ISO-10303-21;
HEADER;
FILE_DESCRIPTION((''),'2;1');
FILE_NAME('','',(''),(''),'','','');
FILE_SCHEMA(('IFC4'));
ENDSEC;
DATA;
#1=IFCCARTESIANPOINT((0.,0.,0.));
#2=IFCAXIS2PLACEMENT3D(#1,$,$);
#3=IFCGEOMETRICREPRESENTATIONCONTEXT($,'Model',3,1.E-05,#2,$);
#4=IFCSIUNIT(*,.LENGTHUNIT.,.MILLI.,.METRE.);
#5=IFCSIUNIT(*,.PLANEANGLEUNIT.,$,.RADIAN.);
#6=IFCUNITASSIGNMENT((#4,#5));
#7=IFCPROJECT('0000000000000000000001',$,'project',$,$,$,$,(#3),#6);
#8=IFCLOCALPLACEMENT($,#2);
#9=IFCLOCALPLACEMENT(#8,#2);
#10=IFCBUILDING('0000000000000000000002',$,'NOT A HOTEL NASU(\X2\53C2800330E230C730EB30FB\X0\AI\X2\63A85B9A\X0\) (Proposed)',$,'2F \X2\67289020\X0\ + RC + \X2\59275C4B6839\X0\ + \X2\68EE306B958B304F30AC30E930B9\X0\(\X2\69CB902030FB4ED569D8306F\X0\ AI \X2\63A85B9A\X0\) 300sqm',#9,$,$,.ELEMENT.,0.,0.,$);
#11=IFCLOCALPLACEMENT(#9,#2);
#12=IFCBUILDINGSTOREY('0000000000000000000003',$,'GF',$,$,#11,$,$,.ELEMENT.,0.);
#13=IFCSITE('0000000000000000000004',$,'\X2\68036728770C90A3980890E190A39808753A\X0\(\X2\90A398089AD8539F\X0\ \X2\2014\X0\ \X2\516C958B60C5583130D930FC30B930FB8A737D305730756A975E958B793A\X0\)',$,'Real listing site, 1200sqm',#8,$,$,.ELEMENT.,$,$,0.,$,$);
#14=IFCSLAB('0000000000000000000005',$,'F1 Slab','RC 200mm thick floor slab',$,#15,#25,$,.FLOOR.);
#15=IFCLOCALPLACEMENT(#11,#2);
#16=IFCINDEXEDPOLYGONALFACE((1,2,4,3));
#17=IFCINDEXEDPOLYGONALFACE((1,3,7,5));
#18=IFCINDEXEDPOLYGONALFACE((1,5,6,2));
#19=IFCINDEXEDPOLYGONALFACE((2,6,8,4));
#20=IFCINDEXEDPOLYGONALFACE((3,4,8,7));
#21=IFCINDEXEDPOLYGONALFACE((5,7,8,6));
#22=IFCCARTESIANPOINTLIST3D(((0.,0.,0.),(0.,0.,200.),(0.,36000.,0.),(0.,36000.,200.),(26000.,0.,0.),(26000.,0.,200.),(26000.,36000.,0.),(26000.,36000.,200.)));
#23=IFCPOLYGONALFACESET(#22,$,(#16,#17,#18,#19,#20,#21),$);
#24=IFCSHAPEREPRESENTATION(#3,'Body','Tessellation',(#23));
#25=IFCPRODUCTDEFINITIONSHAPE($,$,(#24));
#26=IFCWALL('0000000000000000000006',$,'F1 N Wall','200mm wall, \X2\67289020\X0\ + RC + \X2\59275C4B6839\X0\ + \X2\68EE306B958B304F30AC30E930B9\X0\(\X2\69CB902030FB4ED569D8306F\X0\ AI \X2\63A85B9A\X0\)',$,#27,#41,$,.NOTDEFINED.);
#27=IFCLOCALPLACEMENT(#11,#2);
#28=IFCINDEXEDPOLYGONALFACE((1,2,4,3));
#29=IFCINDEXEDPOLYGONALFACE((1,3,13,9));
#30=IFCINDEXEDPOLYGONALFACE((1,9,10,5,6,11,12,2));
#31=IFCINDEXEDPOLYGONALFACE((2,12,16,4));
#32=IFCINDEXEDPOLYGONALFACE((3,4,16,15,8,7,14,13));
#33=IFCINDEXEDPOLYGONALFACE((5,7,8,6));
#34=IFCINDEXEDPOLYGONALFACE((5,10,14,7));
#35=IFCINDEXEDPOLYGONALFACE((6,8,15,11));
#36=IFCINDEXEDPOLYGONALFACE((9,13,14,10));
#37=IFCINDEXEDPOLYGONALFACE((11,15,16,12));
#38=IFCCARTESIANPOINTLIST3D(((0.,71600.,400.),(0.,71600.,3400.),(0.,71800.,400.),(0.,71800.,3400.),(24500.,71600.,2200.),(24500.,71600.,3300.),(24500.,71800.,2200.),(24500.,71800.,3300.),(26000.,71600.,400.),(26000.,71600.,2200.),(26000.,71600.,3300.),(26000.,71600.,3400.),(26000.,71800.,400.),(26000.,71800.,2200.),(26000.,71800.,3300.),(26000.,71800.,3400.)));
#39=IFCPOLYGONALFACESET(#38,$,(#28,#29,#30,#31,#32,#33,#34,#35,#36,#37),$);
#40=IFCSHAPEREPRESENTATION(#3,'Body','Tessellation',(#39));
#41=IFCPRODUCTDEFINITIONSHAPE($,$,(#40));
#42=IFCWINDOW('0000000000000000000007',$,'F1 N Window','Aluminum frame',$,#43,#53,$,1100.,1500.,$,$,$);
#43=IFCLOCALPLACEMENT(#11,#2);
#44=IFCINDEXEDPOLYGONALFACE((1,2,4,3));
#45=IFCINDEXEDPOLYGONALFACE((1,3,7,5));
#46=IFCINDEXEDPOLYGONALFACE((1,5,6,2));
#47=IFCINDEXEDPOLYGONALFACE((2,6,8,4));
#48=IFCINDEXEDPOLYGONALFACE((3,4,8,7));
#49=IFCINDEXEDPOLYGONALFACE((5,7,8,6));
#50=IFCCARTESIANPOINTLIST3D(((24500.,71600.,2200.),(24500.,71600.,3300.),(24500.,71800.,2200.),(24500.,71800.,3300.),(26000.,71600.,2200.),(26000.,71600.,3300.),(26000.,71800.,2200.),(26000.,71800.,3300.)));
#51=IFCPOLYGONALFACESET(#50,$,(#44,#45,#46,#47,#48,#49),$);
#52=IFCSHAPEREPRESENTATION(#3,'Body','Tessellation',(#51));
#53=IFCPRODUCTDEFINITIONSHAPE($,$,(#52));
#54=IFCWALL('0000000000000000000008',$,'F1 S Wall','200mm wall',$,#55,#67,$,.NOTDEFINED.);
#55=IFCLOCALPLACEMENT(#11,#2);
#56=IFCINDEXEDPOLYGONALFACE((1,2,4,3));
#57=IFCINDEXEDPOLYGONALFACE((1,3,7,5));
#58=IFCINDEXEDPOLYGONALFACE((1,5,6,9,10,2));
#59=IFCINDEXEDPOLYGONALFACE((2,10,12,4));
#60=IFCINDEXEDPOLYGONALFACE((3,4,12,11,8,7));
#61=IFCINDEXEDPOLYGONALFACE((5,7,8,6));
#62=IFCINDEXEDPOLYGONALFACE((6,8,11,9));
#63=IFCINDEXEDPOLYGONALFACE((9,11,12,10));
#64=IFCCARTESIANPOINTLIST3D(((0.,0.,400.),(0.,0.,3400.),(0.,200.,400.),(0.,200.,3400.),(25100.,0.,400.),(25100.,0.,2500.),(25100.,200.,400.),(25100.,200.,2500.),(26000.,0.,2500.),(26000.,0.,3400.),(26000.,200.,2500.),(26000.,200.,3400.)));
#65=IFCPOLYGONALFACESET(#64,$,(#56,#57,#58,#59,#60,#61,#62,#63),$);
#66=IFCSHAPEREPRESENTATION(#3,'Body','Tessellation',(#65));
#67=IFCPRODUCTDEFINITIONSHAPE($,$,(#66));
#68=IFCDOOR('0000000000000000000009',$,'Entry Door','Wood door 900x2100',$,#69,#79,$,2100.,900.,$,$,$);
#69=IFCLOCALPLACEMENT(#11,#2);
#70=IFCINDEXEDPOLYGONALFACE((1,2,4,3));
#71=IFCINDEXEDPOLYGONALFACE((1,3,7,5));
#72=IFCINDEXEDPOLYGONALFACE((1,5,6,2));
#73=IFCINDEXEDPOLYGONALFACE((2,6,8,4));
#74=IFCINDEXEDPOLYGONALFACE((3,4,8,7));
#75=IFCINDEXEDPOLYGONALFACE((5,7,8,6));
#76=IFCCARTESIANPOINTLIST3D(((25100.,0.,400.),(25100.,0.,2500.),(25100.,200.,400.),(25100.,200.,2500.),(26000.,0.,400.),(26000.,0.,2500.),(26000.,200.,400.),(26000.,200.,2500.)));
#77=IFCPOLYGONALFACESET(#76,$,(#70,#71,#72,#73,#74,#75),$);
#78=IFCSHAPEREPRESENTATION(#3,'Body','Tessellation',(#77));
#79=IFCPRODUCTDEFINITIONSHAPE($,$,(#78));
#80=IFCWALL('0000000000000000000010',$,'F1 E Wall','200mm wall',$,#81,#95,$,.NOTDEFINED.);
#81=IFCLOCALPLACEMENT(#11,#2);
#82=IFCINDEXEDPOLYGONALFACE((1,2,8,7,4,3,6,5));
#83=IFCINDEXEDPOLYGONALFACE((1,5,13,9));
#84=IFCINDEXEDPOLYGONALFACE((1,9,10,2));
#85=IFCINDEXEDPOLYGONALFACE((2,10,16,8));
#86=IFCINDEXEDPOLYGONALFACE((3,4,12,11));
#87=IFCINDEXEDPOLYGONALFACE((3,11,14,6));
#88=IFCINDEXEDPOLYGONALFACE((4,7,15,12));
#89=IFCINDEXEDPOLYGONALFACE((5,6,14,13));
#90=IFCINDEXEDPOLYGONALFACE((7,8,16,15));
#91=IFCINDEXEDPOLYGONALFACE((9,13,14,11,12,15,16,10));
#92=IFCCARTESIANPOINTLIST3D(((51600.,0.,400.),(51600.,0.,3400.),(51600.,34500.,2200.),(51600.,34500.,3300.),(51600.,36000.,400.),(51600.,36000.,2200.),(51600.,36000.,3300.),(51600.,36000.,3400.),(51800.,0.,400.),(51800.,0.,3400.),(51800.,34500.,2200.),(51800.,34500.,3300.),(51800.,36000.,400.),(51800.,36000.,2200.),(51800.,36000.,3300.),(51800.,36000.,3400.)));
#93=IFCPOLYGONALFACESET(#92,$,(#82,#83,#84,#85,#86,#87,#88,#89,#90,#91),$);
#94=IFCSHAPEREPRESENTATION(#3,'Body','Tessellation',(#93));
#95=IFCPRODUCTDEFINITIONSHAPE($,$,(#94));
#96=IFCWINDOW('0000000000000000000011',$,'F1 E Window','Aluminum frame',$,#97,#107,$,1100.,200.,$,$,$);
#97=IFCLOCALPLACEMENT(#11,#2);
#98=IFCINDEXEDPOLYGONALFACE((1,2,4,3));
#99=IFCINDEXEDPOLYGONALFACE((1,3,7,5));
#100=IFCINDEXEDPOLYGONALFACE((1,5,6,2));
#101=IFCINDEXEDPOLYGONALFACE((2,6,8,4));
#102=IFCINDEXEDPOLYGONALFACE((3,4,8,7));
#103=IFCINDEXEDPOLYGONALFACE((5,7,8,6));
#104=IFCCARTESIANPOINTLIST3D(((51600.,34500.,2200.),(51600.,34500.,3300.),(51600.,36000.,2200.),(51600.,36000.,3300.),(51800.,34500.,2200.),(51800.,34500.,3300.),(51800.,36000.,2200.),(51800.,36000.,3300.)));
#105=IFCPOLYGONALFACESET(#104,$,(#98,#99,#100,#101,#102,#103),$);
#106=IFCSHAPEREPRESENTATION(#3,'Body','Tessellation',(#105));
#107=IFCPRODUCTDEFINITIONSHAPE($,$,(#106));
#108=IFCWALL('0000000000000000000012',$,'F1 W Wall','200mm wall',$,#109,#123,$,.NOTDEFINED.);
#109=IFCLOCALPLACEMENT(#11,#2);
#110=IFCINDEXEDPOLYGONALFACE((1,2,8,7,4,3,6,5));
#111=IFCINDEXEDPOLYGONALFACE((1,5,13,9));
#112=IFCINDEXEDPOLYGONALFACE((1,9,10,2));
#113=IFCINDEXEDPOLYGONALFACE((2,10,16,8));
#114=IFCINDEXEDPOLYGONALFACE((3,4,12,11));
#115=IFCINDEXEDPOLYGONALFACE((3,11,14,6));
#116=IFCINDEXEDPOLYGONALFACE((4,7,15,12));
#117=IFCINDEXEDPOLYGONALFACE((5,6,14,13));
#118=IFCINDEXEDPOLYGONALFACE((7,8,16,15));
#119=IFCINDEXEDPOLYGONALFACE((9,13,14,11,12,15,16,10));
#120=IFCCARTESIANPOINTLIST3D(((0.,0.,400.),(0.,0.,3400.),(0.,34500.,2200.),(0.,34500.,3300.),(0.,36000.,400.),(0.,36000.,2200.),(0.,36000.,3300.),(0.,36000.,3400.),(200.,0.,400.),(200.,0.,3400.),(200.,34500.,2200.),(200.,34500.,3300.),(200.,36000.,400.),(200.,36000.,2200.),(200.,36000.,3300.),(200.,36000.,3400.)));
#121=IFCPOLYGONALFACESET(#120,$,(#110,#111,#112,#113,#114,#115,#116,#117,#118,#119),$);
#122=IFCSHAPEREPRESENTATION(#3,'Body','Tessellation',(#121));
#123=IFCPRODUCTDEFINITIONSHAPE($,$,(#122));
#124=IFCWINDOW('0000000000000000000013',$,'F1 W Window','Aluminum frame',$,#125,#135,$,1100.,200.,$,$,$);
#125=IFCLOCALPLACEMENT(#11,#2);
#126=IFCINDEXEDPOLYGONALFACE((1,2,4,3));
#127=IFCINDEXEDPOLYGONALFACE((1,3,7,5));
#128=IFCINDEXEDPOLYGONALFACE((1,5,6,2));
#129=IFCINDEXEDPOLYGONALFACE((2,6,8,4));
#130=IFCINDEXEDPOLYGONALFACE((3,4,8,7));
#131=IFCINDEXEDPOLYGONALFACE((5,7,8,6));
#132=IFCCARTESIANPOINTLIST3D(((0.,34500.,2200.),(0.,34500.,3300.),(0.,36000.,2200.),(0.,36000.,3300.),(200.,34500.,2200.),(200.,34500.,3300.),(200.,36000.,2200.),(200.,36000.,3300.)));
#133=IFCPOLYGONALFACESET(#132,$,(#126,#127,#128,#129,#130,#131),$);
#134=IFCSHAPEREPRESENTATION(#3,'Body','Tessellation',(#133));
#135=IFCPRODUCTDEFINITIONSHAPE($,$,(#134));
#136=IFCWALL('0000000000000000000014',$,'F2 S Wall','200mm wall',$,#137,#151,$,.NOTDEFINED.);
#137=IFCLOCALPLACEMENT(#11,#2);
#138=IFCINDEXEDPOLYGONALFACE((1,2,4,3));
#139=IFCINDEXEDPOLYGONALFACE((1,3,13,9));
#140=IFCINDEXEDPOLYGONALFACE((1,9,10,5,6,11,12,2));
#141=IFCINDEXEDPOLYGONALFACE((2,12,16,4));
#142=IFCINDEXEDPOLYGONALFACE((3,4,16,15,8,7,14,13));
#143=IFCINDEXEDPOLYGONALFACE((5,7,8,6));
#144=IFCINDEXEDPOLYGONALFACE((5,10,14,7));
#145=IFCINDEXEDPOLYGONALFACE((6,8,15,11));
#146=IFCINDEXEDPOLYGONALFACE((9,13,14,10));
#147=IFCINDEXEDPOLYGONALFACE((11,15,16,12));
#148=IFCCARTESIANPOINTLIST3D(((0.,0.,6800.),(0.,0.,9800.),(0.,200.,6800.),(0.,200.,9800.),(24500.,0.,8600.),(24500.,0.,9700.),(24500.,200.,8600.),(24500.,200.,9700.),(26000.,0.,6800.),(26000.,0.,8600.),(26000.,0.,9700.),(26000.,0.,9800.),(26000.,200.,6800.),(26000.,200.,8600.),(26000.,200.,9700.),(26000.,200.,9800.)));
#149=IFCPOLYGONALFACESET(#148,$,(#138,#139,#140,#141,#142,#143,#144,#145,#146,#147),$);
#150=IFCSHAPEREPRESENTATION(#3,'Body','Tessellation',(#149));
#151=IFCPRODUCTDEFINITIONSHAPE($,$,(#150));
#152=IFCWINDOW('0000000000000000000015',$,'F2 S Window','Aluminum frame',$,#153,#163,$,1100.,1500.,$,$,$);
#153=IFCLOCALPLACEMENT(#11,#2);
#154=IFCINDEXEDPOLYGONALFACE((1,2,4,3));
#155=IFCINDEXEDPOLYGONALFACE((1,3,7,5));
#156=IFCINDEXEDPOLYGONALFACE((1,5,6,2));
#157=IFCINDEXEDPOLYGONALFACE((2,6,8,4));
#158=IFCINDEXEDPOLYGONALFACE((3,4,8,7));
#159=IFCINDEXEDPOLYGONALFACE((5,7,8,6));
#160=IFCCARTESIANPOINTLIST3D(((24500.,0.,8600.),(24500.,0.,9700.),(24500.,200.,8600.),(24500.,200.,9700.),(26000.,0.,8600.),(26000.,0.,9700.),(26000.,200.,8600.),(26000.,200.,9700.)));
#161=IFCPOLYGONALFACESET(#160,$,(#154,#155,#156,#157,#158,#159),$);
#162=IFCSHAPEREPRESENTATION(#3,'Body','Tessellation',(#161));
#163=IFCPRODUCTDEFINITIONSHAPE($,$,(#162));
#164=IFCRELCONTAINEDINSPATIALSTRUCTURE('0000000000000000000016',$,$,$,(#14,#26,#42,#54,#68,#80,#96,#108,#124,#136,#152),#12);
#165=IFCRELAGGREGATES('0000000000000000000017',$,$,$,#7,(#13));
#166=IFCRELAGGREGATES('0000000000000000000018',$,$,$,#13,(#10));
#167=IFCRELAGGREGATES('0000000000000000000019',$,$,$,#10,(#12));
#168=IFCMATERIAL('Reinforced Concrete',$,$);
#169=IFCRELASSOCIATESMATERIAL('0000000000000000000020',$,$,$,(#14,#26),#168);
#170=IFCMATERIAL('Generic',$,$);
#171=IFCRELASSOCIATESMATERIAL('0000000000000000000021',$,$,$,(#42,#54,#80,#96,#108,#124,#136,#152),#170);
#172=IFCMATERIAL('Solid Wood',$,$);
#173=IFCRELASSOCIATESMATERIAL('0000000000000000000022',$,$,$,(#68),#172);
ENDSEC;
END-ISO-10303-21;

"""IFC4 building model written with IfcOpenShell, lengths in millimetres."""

from ifc_helpers import new_model, si_unit, frame, frame_2d, origin, place, context, project, spatial, rectangle, extrude, material, element, fill, save


model = new_model("IFC4")

# Units and contexts
model_context = context("Model", 3, precision=1e-05, world=origin())
ifc_project = project(units=[si_unit("LENGTHUNIT", "METRE", prefix="MILLI"), si_unit("PLANEANGLEUNIT", "RADIAN")], contexts=[model_context])

# Site, building, storey
site_placement = place(None, origin())
site = spatial("IfcSite", under=ifc_project, at=site_placement, Name="栃木県那須郡那須町(那須高原 — 公開情報ベース・詳細地番非開示)", ObjectType="Real listing site, 1200sqm", CompositionType="ELEMENT", RefElevation=0.0)
building_placement = place(site_placement, origin())
building = spatial("IfcBuilding", under=site, at=building_placement, Name="NOT A HOTEL NASU(参考モデル・AI推定) (Proposed)", ObjectType="2F 木造 + RC + 大屋根 + 森に開くガラス(構造・仕様は AI 推定) 300sqm", CompositionType="ELEMENT", ElevationOfRefHeight=0.0, ElevationOfTerrain=0.0)
storey_placement = place(building_placement, origin())
storey = spatial("IfcBuildingStorey", under=building, at=storey_placement, Name="GF", CompositionType="ELEMENT", Elevation=0.0)

# Slab
ifc_material_1 = material(Name="Reinforced Concrete")
slab_1_placement = place(storey_placement, origin())
element("IfcSlab", 1, at=slab_1_placement, inside=storey, material=ifc_material_1, Name="F1 Slab", Description="RC 200mm thick floor slab", PredefinedType="FLOOR", context=model_context, shape_type="SweptSolid", body=[
    extrude(rectangle(XDim=26000.0, YDim=36000.0, at=frame_2d((13000.0, 18000.0))), origin(), (0.0, 0.0, 1.0), 200.0),
])

# Wall, opening, window
wall_1_placement = place(storey_placement, frame((0.0, 35800.0, 200.0)))
wall_1 = element("IfcWall", 2, at=wall_1_placement, inside=storey, material=ifc_material_1, Name="F1 N Wall", Description="200mm wall, 木造 + RC + 大屋根 + 森に開くガラス(構造・仕様は AI 推定)", PredefinedType="NOTDEFINED", context=model_context, shape_type="SweptSolid", body=[
    extrude(rectangle(XDim=26000.0, YDim=200.0, at=frame_2d((13000.0, 100.0))), frame((0.0, 35800.0, 200.0)), (0.0, 0.0, 1.0), 3000.0),
])
opening_1_placement = place(storey_placement, frame((12250.0, 35800.0, 1100.0)))
opening_1 = element("IfcOpeningElement", 3, at=opening_1_placement, cuts=wall_1, PredefinedType="NOTDEFINED", context=model_context, shape_type="SweptSolid", body=[
    extrude(rectangle(XDim=1500.0, YDim=200.0, at=frame_2d((750.0, 100.0))), frame((12250.0, 35800.0, 1100.0)), (0.0, 0.0, 1.0), 1100.0),
])
ifc_material_2 = material(Name="Generic")
window_1_placement = place(storey_placement, frame((12250.0, 35800.0, 1100.0)))
window_1 = element("IfcWindow", 4, at=window_1_placement, inside=storey, material=ifc_material_2, Name="F1 N Window", Description="Aluminum frame", OverallHeight=1100.0, OverallWidth=1500.0, context=model_context, shape_type="SweptSolid", body=[
    extrude(rectangle(XDim=1500.0, YDim=200.0, at=frame_2d((750.0, 100.0))), frame((12250.0, 35800.0, 1100.0)), (0.0, 0.0, 1.0), 1100.0),
])
fill(opening_1, window_1)

# Wall, opening, door
wall_2_placement = place(storey_placement, frame((0.0, 0.0, 200.0)))
wall_2 = element("IfcWall", 5, at=wall_2_placement, inside=storey, material=ifc_material_2, Name="F1 S Wall", Description="200mm wall", PredefinedType="NOTDEFINED", context=model_context, shape_type="SweptSolid", body=[
    extrude(rectangle(XDim=26000.0, YDim=200.0, at=frame_2d((13000.0, 100.0))), frame((0.0, 0.0, 200.0)), (0.0, 0.0, 1.0), 3000.0),
])
opening_2_placement = place(storey_placement, frame((12550.0, 0.0, 200.0)))
opening_2 = element("IfcOpeningElement", 6, at=opening_2_placement, cuts=wall_2, PredefinedType="NOTDEFINED", context=model_context, shape_type="SweptSolid", body=[
    extrude(rectangle(XDim=900.0, YDim=200.0, at=frame_2d((450.0, 100.0))), frame((12550.0, 0.0, 200.0)), (0.0, 0.0, 1.0), 2100.0),
])
ifc_material_3 = material(Name="Solid Wood")
door_placement = place(storey_placement, frame((12550.0, 0.0, 200.0)))
door = element("IfcDoor", 7, at=door_placement, inside=storey, material=ifc_material_3, Name="Entry Door", Description="Wood door 900x2100", OverallHeight=2100.0, OverallWidth=900.0, context=model_context, shape_type="SweptSolid", body=[
    extrude(rectangle(XDim=900.0, YDim=200.0, at=frame_2d((450.0, 100.0))), frame((12550.0, 0.0, 200.0)), (0.0, 0.0, 1.0), 2100.0),
])
fill(opening_2, door)

# Walls, openings, windows
wall_3_placement = place(storey_placement, frame((25800.0, 0.0, 200.0)))
wall_3 = element("IfcWall", 8, at=wall_3_placement, inside=storey, material=ifc_material_2, Name="F1 E Wall", Description="200mm wall", PredefinedType="NOTDEFINED", context=model_context, shape_type="SweptSolid", body=[
    extrude(rectangle(XDim=200.0, YDim=36000.0, at=frame_2d((100.0, 18000.0))), frame((25800.0, 0.0, 200.0)), (0.0, 0.0, 1.0), 3000.0),
])
opening_3_placement = place(storey_placement, frame((25800.0, 17250.0, 1100.0)))
opening_3 = element("IfcOpeningElement", 9, at=opening_3_placement, cuts=wall_3, PredefinedType="NOTDEFINED", context=model_context, shape_type="SweptSolid", body=[
    extrude(rectangle(XDim=200.0, YDim=1500.0, at=frame_2d((100.0, 750.0))), frame((25800.0, 17250.0, 1100.0)), (0.0, 0.0, 1.0), 1100.0),
])
window_2_placement = place(storey_placement, frame((25800.0, 17250.0, 1100.0)))
window_2 = element("IfcWindow", 10, at=window_2_placement, inside=storey, material=ifc_material_2, Name="F1 E Window", Description="Aluminum frame", OverallHeight=1100.0, OverallWidth=200.0, context=model_context, shape_type="SweptSolid", body=[
    extrude(rectangle(XDim=200.0, YDim=1500.0, at=frame_2d((100.0, 750.0))), frame((25800.0, 17250.0, 1100.0)), (0.0, 0.0, 1.0), 1100.0),
])
fill(opening_3, window_2)
wall_4_placement = place(storey_placement, frame((0.0, 0.0, 200.0)))
wall_4 = element("IfcWall", 11, at=wall_4_placement, inside=storey, material=ifc_material_2, Name="F1 W Wall", Description="200mm wall", PredefinedType="NOTDEFINED", context=model_context, shape_type="SweptSolid", body=[
    extrude(rectangle(XDim=200.0, YDim=36000.0, at=frame_2d((100.0, 18000.0))), frame((0.0, 0.0, 200.0)), (0.0, 0.0, 1.0), 3000.0),
])
opening_4_placement = place(storey_placement, frame((0.0, 17250.0, 1100.0)))
opening_4 = element("IfcOpeningElement", 12, at=opening_4_placement, cuts=wall_4, PredefinedType="NOTDEFINED", context=model_context, shape_type="SweptSolid", body=[
    extrude(rectangle(XDim=200.0, YDim=1500.0, at=frame_2d((100.0, 750.0))), frame((0.0, 17250.0, 1100.0)), (0.0, 0.0, 1.0), 1100.0),
])
window_3_placement = place(storey_placement, frame((0.0, 17250.0, 1100.0)))
window_3 = element("IfcWindow", 13, at=window_3_placement, inside=storey, material=ifc_material_2, Name="F1 W Window", Description="Aluminum frame", OverallHeight=1100.0, OverallWidth=200.0, context=model_context, shape_type="SweptSolid", body=[
    extrude(rectangle(XDim=200.0, YDim=1500.0, at=frame_2d((100.0, 750.0))), frame((0.0, 17250.0, 1100.0)), (0.0, 0.0, 1.0), 1100.0),
])
fill(opening_4, window_3)
wall_5_placement = place(storey_placement, frame((0.0, 0.0, 3400.0)))
wall_5 = element("IfcWall", 14, at=wall_5_placement, inside=storey, material=ifc_material_2, Name="F2 S Wall", Description="200mm wall", PredefinedType="NOTDEFINED", context=model_context, shape_type="SweptSolid", body=[
    extrude(rectangle(XDim=26000.0, YDim=200.0, at=frame_2d((13000.0, 100.0))), frame((0.0, 0.0, 3400.0)), (0.0, 0.0, 1.0), 3000.0),
])
opening_5_placement = place(storey_placement, frame((12250.0, 0.0, 4300.0)))
opening_5 = element("IfcOpeningElement", 15, at=opening_5_placement, cuts=wall_5, PredefinedType="NOTDEFINED", context=model_context, shape_type="SweptSolid", body=[
    extrude(rectangle(XDim=1500.0, YDim=200.0, at=frame_2d((750.0, 100.0))), frame((12250.0, 0.0, 4300.0)), (0.0, 0.0, 1.0), 1100.0),
])
window_4_placement = place(storey_placement, frame((12250.0, 0.0, 4300.0)))
window_4 = element("IfcWindow", 16, at=window_4_placement, inside=storey, material=ifc_material_2, Name="F2 S Window", Description="Aluminum frame", OverallHeight=1100.0, OverallWidth=1500.0, context=model_context, shape_type="SweptSolid", body=[
    extrude(rectangle(XDim=1500.0, YDim=200.0, at=frame_2d((750.0, 100.0))), frame((12250.0, 0.0, 4300.0)), (0.0, 0.0, 1.0), 1100.0),
])
fill(opening_5, window_4)

save(model, "model.ifc")
